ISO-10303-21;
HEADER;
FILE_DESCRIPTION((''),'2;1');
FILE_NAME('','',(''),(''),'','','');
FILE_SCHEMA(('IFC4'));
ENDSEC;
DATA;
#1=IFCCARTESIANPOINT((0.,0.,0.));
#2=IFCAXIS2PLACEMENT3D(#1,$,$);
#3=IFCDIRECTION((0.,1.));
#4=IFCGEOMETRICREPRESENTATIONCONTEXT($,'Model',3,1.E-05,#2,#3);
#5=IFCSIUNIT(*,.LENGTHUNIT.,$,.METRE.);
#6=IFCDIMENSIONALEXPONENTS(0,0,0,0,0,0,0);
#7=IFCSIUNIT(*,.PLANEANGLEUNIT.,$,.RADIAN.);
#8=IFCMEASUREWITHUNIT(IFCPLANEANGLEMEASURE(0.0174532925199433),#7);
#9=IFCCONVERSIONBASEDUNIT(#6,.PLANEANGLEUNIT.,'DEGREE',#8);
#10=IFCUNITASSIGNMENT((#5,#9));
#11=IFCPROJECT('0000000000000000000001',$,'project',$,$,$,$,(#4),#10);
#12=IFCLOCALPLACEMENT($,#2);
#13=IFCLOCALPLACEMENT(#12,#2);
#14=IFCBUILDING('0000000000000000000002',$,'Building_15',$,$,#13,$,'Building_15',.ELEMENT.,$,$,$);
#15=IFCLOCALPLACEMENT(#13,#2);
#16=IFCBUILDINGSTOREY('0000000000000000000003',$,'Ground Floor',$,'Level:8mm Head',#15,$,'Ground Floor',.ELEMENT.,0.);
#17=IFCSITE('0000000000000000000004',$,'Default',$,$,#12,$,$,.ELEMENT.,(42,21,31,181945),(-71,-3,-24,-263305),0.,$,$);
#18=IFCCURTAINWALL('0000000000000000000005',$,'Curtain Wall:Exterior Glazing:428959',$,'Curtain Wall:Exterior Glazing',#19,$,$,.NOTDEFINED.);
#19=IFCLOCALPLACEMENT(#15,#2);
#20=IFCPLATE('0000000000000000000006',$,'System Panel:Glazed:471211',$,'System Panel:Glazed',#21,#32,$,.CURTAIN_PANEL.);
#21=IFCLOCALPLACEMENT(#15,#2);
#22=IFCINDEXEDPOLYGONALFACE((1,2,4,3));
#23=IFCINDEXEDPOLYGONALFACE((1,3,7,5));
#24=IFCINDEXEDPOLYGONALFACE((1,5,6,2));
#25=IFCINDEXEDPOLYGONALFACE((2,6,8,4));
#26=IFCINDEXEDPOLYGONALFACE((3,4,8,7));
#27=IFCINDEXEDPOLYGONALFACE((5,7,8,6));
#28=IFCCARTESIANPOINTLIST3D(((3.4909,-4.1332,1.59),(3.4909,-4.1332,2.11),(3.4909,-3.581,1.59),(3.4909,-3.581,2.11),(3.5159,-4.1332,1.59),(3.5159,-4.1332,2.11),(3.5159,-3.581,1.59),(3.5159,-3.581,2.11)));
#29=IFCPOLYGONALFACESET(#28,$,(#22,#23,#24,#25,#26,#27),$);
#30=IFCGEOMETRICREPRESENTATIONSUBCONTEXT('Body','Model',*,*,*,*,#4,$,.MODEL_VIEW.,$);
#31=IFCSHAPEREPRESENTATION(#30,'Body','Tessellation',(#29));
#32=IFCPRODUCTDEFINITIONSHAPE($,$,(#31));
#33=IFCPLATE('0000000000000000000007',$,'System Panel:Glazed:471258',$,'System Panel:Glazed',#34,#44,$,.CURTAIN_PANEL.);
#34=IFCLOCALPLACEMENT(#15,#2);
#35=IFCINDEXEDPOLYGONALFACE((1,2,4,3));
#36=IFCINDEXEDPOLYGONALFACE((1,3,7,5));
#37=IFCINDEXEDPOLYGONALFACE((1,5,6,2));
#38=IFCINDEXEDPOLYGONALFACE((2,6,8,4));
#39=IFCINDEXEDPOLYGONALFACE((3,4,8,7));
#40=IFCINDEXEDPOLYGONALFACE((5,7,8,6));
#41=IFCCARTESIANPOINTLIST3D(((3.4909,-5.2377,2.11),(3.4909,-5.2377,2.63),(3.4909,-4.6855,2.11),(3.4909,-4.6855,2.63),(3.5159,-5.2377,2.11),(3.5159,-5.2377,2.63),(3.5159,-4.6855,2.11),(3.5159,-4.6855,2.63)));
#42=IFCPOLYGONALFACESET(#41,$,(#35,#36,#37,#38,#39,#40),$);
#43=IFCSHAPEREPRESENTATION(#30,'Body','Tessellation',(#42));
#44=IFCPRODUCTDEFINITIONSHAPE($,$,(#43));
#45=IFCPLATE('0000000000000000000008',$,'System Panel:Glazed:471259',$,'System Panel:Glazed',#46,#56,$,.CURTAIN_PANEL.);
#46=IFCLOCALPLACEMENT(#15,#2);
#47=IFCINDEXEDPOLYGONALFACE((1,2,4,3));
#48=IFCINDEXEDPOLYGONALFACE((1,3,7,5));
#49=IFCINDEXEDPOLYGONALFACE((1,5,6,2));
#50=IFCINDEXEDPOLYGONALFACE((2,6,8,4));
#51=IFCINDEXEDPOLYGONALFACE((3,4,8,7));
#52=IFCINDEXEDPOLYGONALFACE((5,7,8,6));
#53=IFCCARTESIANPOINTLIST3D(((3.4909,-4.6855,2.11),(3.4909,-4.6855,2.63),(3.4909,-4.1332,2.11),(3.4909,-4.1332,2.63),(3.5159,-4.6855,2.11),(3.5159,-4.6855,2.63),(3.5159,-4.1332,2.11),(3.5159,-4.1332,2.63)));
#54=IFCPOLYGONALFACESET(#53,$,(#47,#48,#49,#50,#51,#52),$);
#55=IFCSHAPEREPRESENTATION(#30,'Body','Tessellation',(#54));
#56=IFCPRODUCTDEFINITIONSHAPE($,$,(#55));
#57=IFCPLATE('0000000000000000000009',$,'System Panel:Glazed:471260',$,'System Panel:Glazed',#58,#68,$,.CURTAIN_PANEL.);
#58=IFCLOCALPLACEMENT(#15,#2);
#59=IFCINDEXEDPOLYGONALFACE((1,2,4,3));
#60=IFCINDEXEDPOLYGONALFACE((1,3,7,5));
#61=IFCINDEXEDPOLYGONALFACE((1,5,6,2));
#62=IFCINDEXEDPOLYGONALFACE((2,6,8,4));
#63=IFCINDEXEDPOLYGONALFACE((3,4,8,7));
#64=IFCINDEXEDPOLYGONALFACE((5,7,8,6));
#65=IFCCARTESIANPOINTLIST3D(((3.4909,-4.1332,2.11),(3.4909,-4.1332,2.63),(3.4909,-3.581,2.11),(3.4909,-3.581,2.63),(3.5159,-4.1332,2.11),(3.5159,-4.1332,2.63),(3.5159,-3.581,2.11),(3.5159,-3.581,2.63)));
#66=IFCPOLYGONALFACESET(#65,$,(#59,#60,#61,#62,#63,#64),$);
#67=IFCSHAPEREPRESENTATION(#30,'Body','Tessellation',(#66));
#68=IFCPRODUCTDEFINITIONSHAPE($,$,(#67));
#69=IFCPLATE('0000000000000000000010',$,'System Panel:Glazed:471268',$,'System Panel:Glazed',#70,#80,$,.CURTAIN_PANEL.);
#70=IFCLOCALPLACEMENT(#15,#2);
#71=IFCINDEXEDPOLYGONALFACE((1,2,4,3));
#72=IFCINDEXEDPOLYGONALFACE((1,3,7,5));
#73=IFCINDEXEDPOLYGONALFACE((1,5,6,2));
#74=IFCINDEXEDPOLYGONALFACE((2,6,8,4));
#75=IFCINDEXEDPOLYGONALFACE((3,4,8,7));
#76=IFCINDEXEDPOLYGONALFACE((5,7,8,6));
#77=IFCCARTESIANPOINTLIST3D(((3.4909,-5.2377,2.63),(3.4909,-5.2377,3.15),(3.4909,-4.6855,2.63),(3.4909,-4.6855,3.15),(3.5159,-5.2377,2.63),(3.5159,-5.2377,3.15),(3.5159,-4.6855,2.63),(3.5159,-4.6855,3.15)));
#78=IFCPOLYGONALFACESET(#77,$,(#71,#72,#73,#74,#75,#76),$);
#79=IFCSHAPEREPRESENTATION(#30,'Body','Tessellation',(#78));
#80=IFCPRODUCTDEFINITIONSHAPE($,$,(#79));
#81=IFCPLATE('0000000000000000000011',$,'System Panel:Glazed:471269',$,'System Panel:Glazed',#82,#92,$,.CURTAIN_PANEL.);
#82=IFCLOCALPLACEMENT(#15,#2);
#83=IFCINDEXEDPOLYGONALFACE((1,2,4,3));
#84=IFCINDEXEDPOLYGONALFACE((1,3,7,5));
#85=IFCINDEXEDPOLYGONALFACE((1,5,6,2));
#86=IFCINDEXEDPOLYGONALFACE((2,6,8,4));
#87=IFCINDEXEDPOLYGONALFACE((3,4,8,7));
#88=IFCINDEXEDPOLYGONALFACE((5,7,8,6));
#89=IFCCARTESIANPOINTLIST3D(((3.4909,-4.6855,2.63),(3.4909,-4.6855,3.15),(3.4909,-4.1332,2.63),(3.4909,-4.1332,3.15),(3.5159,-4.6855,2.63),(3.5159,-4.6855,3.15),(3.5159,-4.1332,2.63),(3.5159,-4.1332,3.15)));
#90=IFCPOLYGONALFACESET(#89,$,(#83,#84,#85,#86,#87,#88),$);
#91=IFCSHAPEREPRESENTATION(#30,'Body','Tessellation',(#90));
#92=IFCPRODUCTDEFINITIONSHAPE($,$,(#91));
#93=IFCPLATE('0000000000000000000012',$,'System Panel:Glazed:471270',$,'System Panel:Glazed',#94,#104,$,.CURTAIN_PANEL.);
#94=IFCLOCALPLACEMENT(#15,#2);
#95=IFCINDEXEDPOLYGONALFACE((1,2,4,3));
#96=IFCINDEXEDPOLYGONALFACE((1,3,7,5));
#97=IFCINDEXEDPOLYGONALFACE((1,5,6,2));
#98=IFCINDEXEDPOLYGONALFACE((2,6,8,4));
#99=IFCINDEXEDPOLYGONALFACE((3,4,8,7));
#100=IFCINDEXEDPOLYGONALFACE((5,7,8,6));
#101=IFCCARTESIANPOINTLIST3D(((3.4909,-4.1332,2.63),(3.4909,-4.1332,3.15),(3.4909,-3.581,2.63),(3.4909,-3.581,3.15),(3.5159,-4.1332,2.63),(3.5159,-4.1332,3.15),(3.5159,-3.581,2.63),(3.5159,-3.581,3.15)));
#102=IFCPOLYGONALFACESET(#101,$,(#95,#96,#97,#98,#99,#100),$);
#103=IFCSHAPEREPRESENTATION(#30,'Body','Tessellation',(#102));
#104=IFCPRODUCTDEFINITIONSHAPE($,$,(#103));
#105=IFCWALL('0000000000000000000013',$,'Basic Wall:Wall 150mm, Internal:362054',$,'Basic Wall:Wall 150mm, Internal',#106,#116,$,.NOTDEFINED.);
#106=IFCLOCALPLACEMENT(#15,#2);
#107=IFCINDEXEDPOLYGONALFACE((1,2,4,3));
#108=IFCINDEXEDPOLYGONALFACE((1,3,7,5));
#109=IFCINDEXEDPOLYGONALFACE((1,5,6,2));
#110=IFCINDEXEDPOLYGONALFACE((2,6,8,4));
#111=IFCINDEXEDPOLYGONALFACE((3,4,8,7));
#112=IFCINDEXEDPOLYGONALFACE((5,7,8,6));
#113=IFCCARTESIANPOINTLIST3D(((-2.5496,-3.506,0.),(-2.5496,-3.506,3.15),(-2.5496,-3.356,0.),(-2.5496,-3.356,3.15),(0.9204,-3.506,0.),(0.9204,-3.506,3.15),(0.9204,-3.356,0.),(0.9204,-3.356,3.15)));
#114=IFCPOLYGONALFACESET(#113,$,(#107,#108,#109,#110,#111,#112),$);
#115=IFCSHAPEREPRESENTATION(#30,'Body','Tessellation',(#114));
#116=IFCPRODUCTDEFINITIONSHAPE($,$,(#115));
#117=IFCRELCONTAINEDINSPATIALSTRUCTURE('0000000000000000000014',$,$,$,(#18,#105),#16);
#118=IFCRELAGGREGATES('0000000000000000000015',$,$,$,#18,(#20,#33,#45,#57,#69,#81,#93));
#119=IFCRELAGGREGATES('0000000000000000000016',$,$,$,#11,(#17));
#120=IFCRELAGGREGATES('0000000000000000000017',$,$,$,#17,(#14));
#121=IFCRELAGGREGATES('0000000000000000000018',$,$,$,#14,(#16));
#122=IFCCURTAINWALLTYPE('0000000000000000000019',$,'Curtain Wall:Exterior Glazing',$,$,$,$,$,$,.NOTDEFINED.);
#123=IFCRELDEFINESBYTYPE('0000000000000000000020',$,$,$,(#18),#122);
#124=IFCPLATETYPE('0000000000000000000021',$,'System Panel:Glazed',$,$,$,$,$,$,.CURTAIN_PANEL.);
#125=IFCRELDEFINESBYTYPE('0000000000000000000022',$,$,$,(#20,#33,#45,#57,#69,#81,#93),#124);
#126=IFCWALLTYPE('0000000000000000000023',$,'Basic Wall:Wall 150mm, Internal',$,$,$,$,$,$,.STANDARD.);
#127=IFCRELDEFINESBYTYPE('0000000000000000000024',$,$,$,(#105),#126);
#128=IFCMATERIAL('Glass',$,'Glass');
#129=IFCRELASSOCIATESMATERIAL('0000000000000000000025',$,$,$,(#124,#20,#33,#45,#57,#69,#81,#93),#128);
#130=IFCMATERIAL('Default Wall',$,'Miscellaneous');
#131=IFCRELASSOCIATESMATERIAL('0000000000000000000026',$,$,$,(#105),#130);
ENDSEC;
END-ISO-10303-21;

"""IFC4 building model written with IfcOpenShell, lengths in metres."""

from ifc_helpers import new_model, entity, si_unit, converted_unit, direction, frame, origin, place, context, subcontext, project, spatial, indexed_curve, outline, extrude, source, transform, mapped, material, type_object, type_shapes, element, aggregate, save


model = new_model("IFC4")

# Units and contexts
model_context = context("Model", 3, precision=1e-05, world=origin(), true_north=direction((0.0, 1.0)))
body_context = subcontext(model_context, "Body", "Model", "MODEL_VIEW")
ifc_project = project(units=[si_unit("LENGTHUNIT", "METRE"), converted_unit("PLANEANGLEUNIT", "DEGREE", entity("IfcPlaneAngleMeasure", 0.0174532925199433), si_unit("PLANEANGLEUNIT", "RADIAN"), dimensions=[0, 0, 0, 0, 0, 0, 0])], contexts=[model_context])

# Site, building, storey
site_placement = place(None, origin())
site = spatial("IfcSite", under=ifc_project, at=site_placement, Name="Default", CompositionType="ELEMENT", RefLatitude=(42, 21, 31, 181945), RefLongitude=(-71, -3, -24, -263305), RefElevation=0.0)
building_placement = place(site_placement, origin())
building = spatial("IfcBuilding", under=site, at=building_placement, Name="Building_15", LongName="Building_15", CompositionType="ELEMENT")
storey_placement = place(building_placement, origin())
storey = spatial("IfcBuildingStorey", under=building, at=storey_placement, Name="Ground Floor", ObjectType="Level:8mm Head", LongName="Ground Floor", CompositionType="ELEMENT", Elevation=0.0)

# Curtain wall
curtain_wall_type = type_object("IfcCurtainWallType", Name="Curtain Wall:Exterior Glazing", PredefinedType="NOTDEFINED")
curtain_wall_1_placement = place(storey_placement, origin())
curtain_wall_1 = element("IfcCurtainWall", 1, at=curtain_wall_1_placement, inside=storey, type_object=curtain_wall_type, Name="Curtain Wall:Exterior Glazing:428959", ObjectType="Curtain Wall:Exterior Glazing", PredefinedType="NOTDEFINED")

# Plates
ifc_material_1 = material(Name="Glass", Category="Glass")
plate_type_1 = type_object("IfcPlateType", Name="System Panel:Glazed", PredefinedType="CURTAIN_PANEL", material=ifc_material_1)
shared_shape_1 = source(origin(), body_context, "Body", "SweptSolid", [
    extrude(outline(indexed_curve([(-0.0125, -0.2761), (0.0125, -0.2761), (0.0125, 0.2761), (-0.0125, 0.2761), (-0.0125, -0.2761)], self_intersect=False)), frame((0.0, 0.037, 0.0), z_axis=(0.0, 0.0, 1.0), x_axis=(0.0, 1.0, 0.0)), (0.0, 0.0, 1.0), 0.52),
])
type_shapes(plate_type_1, [shared_shape_1])
plate_1_placement = place(curtain_wall_1_placement, frame((3.5404, -3.8571, 1.59), z_axis=(0.0, 0.0, 1.0), x_axis=(0.0, 1.0, 0.0)))
plate_1 = element("IfcPlate", 2, at=plate_1_placement, type_object=plate_type_1, material=ifc_material_1, Name="System Panel:Glazed:471211", ObjectType="System Panel:Glazed", PredefinedType="CURTAIN_PANEL", context=body_context, shape_type="MappedRepresentation", body=[
    mapped(shared_shape_1, transform((0.0, 0.0, 0.0), scale=1.0)),
])
plate_2_placement = place(curtain_wall_1_placement, frame((3.5404, -4.9616, 2.11), z_axis=(0.0, 0.0, 1.0), x_axis=(0.0, 1.0, 0.0)))
plate_2 = element("IfcPlate", 3, at=plate_2_placement, type_object=plate_type_1, material=ifc_material_1, Name="System Panel:Glazed:471258", ObjectType="System Panel:Glazed", PredefinedType="CURTAIN_PANEL", context=body_context, shape_type="MappedRepresentation", body=[
    mapped(shared_shape_1, transform((0.0, 0.0, 0.0), scale=1.0)),
])
plate_3_placement = place(curtain_wall_1_placement, frame((3.5404, -4.4093, 2.11), z_axis=(0.0, 0.0, 1.0), x_axis=(0.0, 1.0, 0.0)))
plate_3 = element("IfcPlate", 4, at=plate_3_placement, type_object=plate_type_1, material=ifc_material_1, Name="System Panel:Glazed:471259", ObjectType="System Panel:Glazed", PredefinedType="CURTAIN_PANEL", context=body_context, shape_type="MappedRepresentation", body=[
    mapped(shared_shape_1, transform((0.0, 0.0, 0.0), scale=1.0)),
])
plate_4_placement = place(curtain_wall_1_placement, frame((3.5404, -3.8571, 2.11), z_axis=(0.0, 0.0, 1.0), x_axis=(0.0, 1.0, 0.0)))
plate_4 = element("IfcPlate", 5, at=plate_4_placement, type_object=plate_type_1, material=ifc_material_1, Name="System Panel:Glazed:471260", ObjectType="System Panel:Glazed", PredefinedType="CURTAIN_PANEL", context=body_context, shape_type="MappedRepresentation", body=[
    mapped(shared_shape_1, transform((0.0, 0.0, 0.0), scale=1.0)),
])
plate_5_placement = place(curtain_wall_1_placement, frame((3.5404, -4.9616, 2.63), z_axis=(0.0, 0.0, 1.0), x_axis=(0.0, 1.0, 0.0)))
plate_5 = element("IfcPlate", 6, at=plate_5_placement, type_object=plate_type_1, material=ifc_material_1, Name="System Panel:Glazed:471268", ObjectType="System Panel:Glazed", PredefinedType="CURTAIN_PANEL", context=body_context, shape_type="MappedRepresentation", body=[
    mapped(shared_shape_1, transform((0.0, 0.0, 0.0), scale=1.0)),
])
plate_6_placement = place(curtain_wall_1_placement, frame((3.5404, -4.4093, 2.63), z_axis=(0.0, 0.0, 1.0), x_axis=(0.0, 1.0, 0.0)))
plate_6 = element("IfcPlate", 7, at=plate_6_placement, type_object=plate_type_1, material=ifc_material_1, Name="System Panel:Glazed:471269", ObjectType="System Panel:Glazed", PredefinedType="CURTAIN_PANEL", context=body_context, shape_type="MappedRepresentation", body=[
    mapped(shared_shape_1, transform((0.0, 0.0, 0.0), scale=1.0)),
])
plate_7_placement = place(curtain_wall_1_placement, frame((3.5404, -3.8571, 2.63), z_axis=(0.0, 0.0, 1.0), x_axis=(0.0, 1.0, 0.0)))
plate_7 = element("IfcPlate", 8, at=plate_7_placement, type_object=plate_type_1, material=ifc_material_1, Name="System Panel:Glazed:471270", ObjectType="System Panel:Glazed", PredefinedType="CURTAIN_PANEL", context=body_context, shape_type="MappedRepresentation", body=[
    mapped(shared_shape_1, transform((0.0, 0.0, 0.0), scale=1.0)),
])
aggregate(curtain_wall_1, [plate_1, plate_2, plate_3, plate_4, plate_5, plate_6, plate_7])

# Wall
ifc_material_2 = material(Name="Default Wall", Category="Miscellaneous")
wall_type = type_object("IfcWallType", Name="Basic Wall:Wall 150mm, Internal", PredefinedType="STANDARD")
wall_placement = place(storey_placement, frame((0.9204, -3.431, 0.0), z_axis=(0.0, 0.0, 1.0), x_axis=(-1.0, 0.0, 0.0)))
element("IfcWall", 9, at=wall_placement, inside=storey, type_object=wall_type, material=ifc_material_2, Name="Basic Wall:Wall 150mm, Internal:362054", ObjectType="Basic Wall:Wall 150mm, Internal", PredefinedType="NOTDEFINED", context=body_context, shape_type="SweptSolid", body=[
    extrude(outline(indexed_curve([(3.47, 0.075), (0.0, 0.075), (0.0, -0.075), (3.47, -0.075), (3.47, 0.075)], self_intersect=False)), origin(), (0.0, 0.0, 1.0), 3.15),
])

save(model, "model.ifc")
